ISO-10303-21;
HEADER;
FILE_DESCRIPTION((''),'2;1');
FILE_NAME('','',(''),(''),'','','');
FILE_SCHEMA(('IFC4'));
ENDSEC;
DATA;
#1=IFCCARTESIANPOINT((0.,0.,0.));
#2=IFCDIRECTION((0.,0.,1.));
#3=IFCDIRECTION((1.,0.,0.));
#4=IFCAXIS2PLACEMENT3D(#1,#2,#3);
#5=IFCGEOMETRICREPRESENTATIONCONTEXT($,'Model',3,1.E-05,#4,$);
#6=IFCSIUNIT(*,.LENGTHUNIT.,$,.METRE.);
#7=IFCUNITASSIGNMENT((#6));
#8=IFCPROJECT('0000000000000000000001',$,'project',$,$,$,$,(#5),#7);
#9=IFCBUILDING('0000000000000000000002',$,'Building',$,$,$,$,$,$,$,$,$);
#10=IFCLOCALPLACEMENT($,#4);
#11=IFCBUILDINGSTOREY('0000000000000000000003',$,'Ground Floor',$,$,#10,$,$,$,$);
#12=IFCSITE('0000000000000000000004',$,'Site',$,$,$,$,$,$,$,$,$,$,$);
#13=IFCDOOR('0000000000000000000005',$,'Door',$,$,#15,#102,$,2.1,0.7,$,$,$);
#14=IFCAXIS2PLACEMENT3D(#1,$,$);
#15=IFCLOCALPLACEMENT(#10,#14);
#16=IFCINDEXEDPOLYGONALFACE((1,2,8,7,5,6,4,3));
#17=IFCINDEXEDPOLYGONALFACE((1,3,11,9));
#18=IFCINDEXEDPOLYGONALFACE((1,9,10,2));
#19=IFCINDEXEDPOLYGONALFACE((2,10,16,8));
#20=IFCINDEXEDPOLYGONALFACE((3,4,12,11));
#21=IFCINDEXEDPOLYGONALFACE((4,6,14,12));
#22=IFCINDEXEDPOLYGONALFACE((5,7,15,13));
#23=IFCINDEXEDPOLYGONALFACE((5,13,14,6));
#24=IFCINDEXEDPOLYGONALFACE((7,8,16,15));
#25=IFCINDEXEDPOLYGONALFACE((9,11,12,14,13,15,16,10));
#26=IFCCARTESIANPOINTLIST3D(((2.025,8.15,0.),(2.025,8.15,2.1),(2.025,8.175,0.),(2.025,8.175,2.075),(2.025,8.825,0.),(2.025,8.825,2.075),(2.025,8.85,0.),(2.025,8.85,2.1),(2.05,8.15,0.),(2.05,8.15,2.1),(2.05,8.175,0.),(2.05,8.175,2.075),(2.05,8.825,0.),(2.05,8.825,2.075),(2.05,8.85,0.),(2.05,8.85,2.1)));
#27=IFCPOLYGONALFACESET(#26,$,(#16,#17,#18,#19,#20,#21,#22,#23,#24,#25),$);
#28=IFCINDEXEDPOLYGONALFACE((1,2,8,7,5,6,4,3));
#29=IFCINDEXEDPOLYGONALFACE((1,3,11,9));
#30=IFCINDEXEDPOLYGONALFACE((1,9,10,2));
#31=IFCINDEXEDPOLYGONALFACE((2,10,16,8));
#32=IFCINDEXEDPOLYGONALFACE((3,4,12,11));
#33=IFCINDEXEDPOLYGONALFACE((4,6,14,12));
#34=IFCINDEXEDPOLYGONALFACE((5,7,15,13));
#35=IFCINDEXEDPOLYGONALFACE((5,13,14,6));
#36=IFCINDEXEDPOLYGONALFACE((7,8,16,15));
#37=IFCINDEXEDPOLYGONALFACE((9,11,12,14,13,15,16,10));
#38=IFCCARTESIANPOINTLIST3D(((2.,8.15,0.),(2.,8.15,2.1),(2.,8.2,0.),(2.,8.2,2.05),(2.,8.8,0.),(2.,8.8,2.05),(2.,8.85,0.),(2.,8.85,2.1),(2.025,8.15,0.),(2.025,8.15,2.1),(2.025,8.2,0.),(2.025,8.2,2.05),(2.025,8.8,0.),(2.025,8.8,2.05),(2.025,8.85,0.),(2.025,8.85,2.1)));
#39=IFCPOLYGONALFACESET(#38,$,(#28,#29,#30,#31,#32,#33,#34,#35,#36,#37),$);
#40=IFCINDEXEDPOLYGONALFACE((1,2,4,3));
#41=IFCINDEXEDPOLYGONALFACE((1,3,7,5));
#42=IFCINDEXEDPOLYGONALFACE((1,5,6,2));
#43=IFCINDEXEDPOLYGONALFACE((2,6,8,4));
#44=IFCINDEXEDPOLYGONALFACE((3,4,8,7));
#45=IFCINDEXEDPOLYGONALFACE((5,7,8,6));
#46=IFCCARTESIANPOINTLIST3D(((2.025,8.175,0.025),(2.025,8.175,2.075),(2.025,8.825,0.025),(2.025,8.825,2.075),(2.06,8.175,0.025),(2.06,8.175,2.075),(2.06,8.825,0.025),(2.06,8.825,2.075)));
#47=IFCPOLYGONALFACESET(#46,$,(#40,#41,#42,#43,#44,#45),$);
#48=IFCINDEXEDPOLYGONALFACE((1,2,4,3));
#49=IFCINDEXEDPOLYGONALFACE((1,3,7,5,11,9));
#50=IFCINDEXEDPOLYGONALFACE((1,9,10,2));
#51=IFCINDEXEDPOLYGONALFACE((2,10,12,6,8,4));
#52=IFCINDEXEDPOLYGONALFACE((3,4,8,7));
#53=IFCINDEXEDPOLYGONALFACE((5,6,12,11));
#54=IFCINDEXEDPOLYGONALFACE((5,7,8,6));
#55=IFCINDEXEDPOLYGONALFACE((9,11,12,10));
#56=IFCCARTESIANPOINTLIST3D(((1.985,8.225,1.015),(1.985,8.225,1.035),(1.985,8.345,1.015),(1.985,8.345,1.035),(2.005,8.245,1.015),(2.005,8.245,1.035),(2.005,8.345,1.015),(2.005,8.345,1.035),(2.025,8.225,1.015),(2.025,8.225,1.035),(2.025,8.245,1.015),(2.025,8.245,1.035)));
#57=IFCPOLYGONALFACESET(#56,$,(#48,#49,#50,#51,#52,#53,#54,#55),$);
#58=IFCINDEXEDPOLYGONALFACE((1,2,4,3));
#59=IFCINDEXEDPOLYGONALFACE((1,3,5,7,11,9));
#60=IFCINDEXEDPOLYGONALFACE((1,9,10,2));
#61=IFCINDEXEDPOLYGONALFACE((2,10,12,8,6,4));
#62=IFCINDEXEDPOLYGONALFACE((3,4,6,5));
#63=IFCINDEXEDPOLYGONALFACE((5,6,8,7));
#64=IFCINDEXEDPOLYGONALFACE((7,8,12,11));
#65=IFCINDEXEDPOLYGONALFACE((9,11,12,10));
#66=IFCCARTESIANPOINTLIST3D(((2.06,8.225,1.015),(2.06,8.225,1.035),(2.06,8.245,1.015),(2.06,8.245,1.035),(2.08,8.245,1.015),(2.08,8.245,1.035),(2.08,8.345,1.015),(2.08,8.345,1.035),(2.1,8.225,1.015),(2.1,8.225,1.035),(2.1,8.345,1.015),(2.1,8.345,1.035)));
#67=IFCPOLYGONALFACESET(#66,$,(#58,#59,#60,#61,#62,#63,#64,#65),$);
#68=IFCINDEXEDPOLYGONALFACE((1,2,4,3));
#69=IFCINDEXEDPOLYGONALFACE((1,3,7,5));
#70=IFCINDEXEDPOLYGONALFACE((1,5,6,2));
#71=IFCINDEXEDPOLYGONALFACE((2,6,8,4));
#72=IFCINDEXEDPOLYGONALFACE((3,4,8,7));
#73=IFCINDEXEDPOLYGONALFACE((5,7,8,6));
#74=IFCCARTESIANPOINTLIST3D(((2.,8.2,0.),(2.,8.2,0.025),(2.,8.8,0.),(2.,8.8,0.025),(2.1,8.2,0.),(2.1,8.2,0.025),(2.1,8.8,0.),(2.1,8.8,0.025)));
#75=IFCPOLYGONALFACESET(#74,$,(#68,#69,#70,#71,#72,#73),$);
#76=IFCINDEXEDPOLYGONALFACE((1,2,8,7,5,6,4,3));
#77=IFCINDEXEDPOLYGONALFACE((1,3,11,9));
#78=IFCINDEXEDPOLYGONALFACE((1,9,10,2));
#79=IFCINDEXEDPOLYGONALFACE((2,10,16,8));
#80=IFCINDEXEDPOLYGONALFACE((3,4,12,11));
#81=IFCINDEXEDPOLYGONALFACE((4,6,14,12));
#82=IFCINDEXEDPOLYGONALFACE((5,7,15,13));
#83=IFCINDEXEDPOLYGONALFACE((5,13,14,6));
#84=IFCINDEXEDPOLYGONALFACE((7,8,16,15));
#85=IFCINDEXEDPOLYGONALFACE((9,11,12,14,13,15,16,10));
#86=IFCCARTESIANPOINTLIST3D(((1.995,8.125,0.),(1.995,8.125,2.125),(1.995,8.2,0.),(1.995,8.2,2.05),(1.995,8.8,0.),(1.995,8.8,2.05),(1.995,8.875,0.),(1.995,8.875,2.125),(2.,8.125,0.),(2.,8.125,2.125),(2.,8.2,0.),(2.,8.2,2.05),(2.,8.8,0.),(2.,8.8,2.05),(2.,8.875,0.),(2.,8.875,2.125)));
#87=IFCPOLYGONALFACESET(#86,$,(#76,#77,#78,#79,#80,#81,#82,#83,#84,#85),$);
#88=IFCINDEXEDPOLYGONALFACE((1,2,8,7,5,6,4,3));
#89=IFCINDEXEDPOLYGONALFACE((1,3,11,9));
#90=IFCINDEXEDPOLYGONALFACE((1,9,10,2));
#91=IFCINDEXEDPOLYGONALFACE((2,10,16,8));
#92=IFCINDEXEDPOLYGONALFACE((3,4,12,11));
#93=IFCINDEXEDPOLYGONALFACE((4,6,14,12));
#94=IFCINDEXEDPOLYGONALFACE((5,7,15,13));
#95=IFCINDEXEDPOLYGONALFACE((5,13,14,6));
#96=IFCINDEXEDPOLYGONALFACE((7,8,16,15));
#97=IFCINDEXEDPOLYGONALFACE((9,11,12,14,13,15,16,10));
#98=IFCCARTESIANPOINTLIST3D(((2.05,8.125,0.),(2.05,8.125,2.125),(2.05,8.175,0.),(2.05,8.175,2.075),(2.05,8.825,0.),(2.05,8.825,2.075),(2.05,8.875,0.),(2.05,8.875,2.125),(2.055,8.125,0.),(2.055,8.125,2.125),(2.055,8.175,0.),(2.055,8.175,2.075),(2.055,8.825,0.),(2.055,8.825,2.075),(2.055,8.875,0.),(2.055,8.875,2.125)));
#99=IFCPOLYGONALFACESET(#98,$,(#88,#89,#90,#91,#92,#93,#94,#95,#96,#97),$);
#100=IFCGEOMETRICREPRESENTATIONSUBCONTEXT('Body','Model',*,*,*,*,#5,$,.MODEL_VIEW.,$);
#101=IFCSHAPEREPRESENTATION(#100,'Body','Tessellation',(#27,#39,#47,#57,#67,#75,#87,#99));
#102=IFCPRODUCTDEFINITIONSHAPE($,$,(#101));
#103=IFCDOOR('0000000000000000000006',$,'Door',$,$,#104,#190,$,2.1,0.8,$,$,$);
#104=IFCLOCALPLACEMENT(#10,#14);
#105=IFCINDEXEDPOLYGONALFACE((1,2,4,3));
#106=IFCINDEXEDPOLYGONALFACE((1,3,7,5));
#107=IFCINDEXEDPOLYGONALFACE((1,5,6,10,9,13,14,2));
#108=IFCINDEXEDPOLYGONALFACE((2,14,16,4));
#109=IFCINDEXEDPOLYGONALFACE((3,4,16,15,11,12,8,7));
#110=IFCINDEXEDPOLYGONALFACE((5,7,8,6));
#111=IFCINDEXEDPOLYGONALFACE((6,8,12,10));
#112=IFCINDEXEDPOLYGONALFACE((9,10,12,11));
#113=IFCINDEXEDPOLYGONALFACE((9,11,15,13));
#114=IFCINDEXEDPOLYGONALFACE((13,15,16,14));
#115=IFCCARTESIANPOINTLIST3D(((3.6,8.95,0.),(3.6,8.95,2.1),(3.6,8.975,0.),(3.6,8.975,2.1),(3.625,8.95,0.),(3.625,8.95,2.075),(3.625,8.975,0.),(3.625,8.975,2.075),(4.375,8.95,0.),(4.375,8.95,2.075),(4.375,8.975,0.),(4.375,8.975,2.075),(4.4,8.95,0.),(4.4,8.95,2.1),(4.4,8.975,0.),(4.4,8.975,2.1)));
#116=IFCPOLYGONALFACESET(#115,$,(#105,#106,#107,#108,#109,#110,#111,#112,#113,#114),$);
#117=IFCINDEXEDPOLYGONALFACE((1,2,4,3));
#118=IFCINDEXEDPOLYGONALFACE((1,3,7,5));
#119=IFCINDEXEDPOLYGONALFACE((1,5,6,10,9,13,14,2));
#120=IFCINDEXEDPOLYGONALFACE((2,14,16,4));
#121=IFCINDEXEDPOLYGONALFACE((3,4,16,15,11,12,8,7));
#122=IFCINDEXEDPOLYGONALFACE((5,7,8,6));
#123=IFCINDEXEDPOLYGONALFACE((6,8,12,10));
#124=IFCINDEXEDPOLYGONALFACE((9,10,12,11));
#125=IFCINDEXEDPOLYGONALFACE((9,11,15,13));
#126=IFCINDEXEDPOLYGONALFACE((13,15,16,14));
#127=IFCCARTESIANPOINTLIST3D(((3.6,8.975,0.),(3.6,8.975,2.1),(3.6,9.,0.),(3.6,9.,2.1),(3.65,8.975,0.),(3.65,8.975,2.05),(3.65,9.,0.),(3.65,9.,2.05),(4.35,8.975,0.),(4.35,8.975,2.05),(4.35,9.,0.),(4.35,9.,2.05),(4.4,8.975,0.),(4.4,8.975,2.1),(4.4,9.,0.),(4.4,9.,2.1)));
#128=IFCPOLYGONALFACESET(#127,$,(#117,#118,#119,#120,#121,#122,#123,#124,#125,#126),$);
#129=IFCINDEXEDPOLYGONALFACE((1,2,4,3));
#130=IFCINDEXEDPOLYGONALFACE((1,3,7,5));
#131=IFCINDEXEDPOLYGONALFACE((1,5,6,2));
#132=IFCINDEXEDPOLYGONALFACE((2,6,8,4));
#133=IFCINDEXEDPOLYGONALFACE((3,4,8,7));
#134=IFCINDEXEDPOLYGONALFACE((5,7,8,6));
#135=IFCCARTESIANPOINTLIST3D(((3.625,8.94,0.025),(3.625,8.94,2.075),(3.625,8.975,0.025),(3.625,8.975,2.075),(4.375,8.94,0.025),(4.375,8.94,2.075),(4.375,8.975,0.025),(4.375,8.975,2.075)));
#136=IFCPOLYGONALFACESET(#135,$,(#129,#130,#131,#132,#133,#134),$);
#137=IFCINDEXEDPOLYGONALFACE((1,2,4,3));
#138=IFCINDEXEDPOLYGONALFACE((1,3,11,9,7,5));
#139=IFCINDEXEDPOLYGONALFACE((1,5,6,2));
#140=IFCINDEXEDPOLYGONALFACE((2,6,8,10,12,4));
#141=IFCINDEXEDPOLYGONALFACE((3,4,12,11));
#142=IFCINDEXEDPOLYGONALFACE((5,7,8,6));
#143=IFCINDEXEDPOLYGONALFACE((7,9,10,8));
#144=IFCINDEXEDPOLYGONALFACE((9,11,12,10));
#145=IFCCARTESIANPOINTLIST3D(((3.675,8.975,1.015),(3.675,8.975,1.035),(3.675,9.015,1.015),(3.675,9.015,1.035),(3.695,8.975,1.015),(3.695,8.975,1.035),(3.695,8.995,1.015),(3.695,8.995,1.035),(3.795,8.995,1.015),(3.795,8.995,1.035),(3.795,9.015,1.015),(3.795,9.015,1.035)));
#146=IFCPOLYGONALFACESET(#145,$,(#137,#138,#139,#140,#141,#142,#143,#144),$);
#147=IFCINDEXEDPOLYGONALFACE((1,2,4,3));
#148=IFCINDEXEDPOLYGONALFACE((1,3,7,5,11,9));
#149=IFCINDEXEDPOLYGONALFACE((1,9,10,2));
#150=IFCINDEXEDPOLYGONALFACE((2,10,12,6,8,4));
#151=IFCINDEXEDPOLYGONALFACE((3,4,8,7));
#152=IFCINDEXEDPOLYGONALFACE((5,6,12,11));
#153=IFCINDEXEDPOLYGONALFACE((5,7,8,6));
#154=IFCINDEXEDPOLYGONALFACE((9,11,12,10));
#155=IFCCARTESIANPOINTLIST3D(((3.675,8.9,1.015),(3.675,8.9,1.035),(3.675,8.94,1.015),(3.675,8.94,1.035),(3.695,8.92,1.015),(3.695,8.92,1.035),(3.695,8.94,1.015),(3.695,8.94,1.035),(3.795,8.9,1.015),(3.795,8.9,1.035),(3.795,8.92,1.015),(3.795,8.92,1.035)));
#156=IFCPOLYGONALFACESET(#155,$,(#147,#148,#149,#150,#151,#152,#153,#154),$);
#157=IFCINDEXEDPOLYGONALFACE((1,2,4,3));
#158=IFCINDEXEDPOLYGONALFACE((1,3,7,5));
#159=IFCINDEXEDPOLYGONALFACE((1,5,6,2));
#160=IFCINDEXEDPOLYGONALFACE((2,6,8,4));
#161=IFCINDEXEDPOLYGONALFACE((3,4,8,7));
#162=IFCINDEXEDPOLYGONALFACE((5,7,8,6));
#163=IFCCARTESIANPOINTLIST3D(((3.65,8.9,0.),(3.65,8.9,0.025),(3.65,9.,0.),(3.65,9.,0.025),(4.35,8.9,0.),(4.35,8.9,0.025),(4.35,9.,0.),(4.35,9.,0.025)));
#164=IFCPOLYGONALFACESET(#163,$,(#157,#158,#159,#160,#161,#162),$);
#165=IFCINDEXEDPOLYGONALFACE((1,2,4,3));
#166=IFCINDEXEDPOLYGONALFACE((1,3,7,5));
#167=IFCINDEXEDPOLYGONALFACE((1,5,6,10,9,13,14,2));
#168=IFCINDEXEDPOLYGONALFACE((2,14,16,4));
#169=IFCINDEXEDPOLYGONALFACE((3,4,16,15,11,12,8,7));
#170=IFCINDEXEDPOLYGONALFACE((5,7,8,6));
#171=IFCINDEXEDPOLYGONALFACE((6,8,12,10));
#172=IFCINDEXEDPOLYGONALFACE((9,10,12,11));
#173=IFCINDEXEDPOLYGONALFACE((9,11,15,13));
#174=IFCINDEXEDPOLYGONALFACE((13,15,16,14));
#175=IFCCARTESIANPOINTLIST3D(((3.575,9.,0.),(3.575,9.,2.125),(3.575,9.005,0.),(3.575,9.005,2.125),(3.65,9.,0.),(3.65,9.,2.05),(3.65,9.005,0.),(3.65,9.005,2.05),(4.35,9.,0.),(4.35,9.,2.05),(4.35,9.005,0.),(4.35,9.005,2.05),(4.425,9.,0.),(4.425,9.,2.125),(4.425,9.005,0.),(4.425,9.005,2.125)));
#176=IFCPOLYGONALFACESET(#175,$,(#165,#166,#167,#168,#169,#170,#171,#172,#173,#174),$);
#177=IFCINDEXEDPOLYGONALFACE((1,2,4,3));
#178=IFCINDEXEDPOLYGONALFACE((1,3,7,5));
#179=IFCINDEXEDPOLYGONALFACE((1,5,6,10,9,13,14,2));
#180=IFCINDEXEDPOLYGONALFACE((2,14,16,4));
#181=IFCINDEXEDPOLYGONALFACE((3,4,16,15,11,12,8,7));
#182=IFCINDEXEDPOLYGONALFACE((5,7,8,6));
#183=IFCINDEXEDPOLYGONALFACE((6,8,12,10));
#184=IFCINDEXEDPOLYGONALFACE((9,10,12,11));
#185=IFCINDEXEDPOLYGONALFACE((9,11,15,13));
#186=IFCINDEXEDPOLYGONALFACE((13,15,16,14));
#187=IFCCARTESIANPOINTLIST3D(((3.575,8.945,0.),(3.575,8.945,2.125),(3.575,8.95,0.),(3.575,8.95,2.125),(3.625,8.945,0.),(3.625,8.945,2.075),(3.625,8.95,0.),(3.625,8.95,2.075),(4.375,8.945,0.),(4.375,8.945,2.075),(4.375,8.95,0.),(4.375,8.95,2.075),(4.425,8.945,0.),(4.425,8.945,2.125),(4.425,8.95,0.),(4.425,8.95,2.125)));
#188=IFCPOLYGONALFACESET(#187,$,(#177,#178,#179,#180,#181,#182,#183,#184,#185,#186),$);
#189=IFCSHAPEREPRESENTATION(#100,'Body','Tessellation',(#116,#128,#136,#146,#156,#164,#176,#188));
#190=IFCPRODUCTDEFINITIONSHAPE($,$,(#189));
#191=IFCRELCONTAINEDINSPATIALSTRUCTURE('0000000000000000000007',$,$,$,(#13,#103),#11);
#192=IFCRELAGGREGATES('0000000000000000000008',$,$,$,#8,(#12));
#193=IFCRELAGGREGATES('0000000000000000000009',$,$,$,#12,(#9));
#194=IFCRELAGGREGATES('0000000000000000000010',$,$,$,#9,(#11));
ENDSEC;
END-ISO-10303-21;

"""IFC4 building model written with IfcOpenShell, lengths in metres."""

from ifc_helpers import new_model, si_unit, frame, origin_with_axes, place, context, subcontext, project, spatial, line, indexed_curve, outline, extrude, element, save


model = new_model("IFC4")

# Units and contexts
model_context = context("Model", 3, precision=1e-05, world=origin_with_axes())
body_context = subcontext(model_context, "Body", "Model", "MODEL_VIEW")
ifc_project = project(units=[si_unit("LENGTHUNIT", "METRE")], contexts=[model_context])

# Site, building, storey
site = spatial("IfcSite", under=ifc_project, Name="Site")
building = spatial("IfcBuilding", under=site, Name="Building")
storey_placement = place(None, origin_with_axes())
storey = spatial("IfcBuildingStorey", under=building, at=storey_placement, Name="Ground Floor")

# Doors
door_1_placement = place(storey_placement, frame((2.0, 8.85, 0.0), z_axis=(0.0, 0.0, 1.0), x_axis=(0.0, -1.0, 0.0)))
element("IfcDoor", 1, at=door_1_placement, inside=storey, Name="Door", OverallHeight=2.1, OverallWidth=0.7, context=body_context, shape_type="SweptSolid", body=[
    extrude(outline(indexed_curve([(0.0, 0.0), (0.0, 2.1), (0.7, 2.1), (0.7, 0.0), (0.675, 0.0), (0.675, 2.075), (0.025, 2.075), (0.025, 0.0)], segments=[line(1, 2, 3, 4, 5, 6, 7, 8, 1)])), frame((0.0, 0.025, 0.0), z_axis=(0.0, -1.0, 0.0), x_axis=(1.0, 0.0, 0.0)), (0.0, 0.0, -1.0), 0.025),
    extrude(outline(indexed_curve([(0.0, 0.0), (0.0, 2.1), (0.7, 2.1), (0.7, 0.0), (0.65, 0.0), (0.65, 2.05), (0.05, 2.05), (0.05, 0.0)], segments=[line(1, 2, 3, 4, 5, 6, 7, 8, 1)])), frame((0.0, 0.0, 0.0), z_axis=(0.0, -1.0, 0.0), x_axis=(1.0, 0.0, 0.0)), (0.0, 0.0, -1.0), 0.025),
    extrude(outline(indexed_curve([(0.0, 0.0), (0.65, 0.0), (0.65, 0.035), (0.0, 0.035)], segments=[line(1, 2, 3, 4, 1)])), frame((0.025, 0.025, 0.025), z_axis=(0.0, 0.0, 1.0), x_axis=(1.0, 0.0, 0.0)), (0.0, 0.0, 1.0), 2.05),
    extrude(outline(indexed_curve([(0.0, 0.0), (0.0, -0.04), (-0.12, -0.04), (-0.12, -0.02), (-0.02, -0.02), (-0.02, 0.0)], segments=[line(1, 2, 3, 4, 5, 6, 1)])), frame((0.625, 0.025, 1.015), z_axis=(0.0, 0.0, 1.0), x_axis=(1.0, 0.0, 0.0)), (0.0, 0.0, 1.0), 0.02),
    extrude(outline(indexed_curve([(0.0, 0.0), (0.0, 0.04), (-0.12, 0.04), (-0.12, 0.02), (-0.02, 0.02), (-0.02, 0.0)], segments=[line(1, 2, 3, 4, 5, 6, 1)])), frame((0.625, 0.06, 1.015), z_axis=(0.0, 0.0, 1.0), x_axis=(1.0, 0.0, 0.0)), (0.0, 0.0, 1.0), 0.02),
    extrude(outline(indexed_curve([(0.0, 0.0), (0.6, 0.0), (0.6, 0.1), (0.0, 0.1)], segments=[line(1, 2, 3, 4, 1)])), frame((0.05, 0.0, 0.0), z_axis=(0.0, 0.0, 1.0), x_axis=(1.0, 0.0, 0.0)), (0.0, 0.0, 1.0), 0.025),
    extrude(outline(indexed_curve([(0.0, 0.0), (0.0, 2.125), (0.75, 2.125), (0.75, 0.0), (0.675, 0.0), (0.675, 2.05), (0.075, 2.05), (0.075, 0.0)], segments=[line(1, 2, 3, 4, 5, 6, 7, 8, 1)])), frame((-0.025, -0.005, 0.0), z_axis=(0.0, -1.0, 0.0), x_axis=(1.0, 0.0, 0.0)), (0.0, 0.0, -1.0), 0.005),
    extrude(outline(indexed_curve([(0.0, 0.0), (0.0, 2.125), (0.75, 2.125), (0.75, 0.0), (0.7, 0.0), (0.7, 2.075), (0.05, 2.075), (0.05, 0.0)], segments=[line(1, 2, 3, 4, 5, 6, 7, 8, 1)])), frame((-0.025, 0.05, 0.0), z_axis=(0.0, -1.0, 0.0), x_axis=(1.0, 0.0, 0.0)), (0.0, 0.0, -1.0), 0.005),
])
door_2_placement = place(storey_placement, frame((4.4, 9.0, 0.0), z_axis=(0.0, 0.0, 1.0), x_axis=(-1.0, 0.0, 0.0)))
element("IfcDoor", 2, at=door_2_placement, inside=storey, Name="Door", OverallHeight=2.1, OverallWidth=0.8, context=body_context, shape_type="SweptSolid", body=[
    extrude(outline(indexed_curve([(0.0, 0.0), (0.0, 2.1), (0.8, 2.1), (0.8, 0.0), (0.775, 0.0), (0.775, 2.075), (0.025, 2.075), (0.025, 0.0)], segments=[line(1, 2, 3, 4, 5, 6, 7, 8, 1)])), frame((0.0, 0.025, 0.0), z_axis=(0.0, -1.0, 0.0), x_axis=(1.0, 0.0, 0.0)), (0.0, 0.0, -1.0), 0.025),
    extrude(outline(indexed_curve([(0.0, 0.0), (0.0, 2.1), (0.8, 2.1), (0.8, 0.0), (0.75, 0.0), (0.75, 2.05), (0.05, 2.05), (0.05, 0.0)], segments=[line(1, 2, 3, 4, 5, 6, 7, 8, 1)])), frame((0.0, 0.0, 0.0), z_axis=(0.0, -1.0, 0.0), x_axis=(1.0, 0.0, 0.0)), (0.0, 0.0, -1.0), 0.025),
    extrude(outline(indexed_curve([(0.0, 0.0), (0.75, 0.0), (0.75, 0.035), (0.0, 0.035)], segments=[line(1, 2, 3, 4, 1)])), frame((0.025, 0.025, 0.025), z_axis=(0.0, 0.0, 1.0), x_axis=(1.0, 0.0, 0.0)), (0.0, 0.0, 1.0), 2.05),
    extrude(outline(indexed_curve([(0.0, 0.0), (0.0, -0.04), (-0.12, -0.04), (-0.12, -0.02), (-0.02, -0.02), (-0.02, 0.0)], segments=[line(1, 2, 3, 4, 5, 6, 1)])), frame((0.725, 0.025, 1.015), z_axis=(0.0, 0.0, 1.0), x_axis=(1.0, 0.0, 0.0)), (0.0, 0.0, 1.0), 0.02),
    extrude(outline(indexed_curve([(0.0, 0.0), (0.0, 0.04), (-0.12, 0.04), (-0.12, 0.02), (-0.02, 0.02), (-0.02, 0.0)], segments=[line(1, 2, 3, 4, 5, 6, 1)])), frame((0.725, 0.06, 1.015), z_axis=(0.0, 0.0, 1.0), x_axis=(1.0, 0.0, 0.0)), (0.0, 0.0, 1.0), 0.02),
    extrude(outline(indexed_curve([(0.0, 0.0), (0.7, 0.0), (0.7, 0.1), (0.0, 0.1)], segments=[line(1, 2, 3, 4, 1)])), frame((0.05, 0.0, 0.0), z_axis=(0.0, 0.0, 1.0), x_axis=(1.0, 0.0, 0.0)), (0.0, 0.0, 1.0), 0.025),
    extrude(outline(indexed_curve([(0.0, 0.0), (0.0, 2.125), (0.85, 2.125), (0.85, 0.0), (0.775, 0.0), (0.775, 2.05), (0.075, 2.05), (0.075, 0.0)], segments=[line(1, 2, 3, 4, 5, 6, 7, 8, 1)])), frame((-0.025, -0.005, 0.0), z_axis=(0.0, -1.0, 0.0), x_axis=(1.0, 0.0, 0.0)), (0.0, 0.0, -1.0), 0.005),
    extrude(outline(indexed_curve([(0.0, 0.0), (0.0, 2.125), (0.85, 2.125), (0.85, 0.0), (0.8, 0.0), (0.8, 2.075), (0.05, 2.075), (0.05, 0.0)], segments=[line(1, 2, 3, 4, 5, 6, 7, 8, 1)])), frame((-0.025, 0.05, 0.0), z_axis=(0.0, -1.0, 0.0), x_axis=(1.0, 0.0, 0.0)), (0.0, 0.0, -1.0), 0.005),
])

save(model, "model.ifc")
